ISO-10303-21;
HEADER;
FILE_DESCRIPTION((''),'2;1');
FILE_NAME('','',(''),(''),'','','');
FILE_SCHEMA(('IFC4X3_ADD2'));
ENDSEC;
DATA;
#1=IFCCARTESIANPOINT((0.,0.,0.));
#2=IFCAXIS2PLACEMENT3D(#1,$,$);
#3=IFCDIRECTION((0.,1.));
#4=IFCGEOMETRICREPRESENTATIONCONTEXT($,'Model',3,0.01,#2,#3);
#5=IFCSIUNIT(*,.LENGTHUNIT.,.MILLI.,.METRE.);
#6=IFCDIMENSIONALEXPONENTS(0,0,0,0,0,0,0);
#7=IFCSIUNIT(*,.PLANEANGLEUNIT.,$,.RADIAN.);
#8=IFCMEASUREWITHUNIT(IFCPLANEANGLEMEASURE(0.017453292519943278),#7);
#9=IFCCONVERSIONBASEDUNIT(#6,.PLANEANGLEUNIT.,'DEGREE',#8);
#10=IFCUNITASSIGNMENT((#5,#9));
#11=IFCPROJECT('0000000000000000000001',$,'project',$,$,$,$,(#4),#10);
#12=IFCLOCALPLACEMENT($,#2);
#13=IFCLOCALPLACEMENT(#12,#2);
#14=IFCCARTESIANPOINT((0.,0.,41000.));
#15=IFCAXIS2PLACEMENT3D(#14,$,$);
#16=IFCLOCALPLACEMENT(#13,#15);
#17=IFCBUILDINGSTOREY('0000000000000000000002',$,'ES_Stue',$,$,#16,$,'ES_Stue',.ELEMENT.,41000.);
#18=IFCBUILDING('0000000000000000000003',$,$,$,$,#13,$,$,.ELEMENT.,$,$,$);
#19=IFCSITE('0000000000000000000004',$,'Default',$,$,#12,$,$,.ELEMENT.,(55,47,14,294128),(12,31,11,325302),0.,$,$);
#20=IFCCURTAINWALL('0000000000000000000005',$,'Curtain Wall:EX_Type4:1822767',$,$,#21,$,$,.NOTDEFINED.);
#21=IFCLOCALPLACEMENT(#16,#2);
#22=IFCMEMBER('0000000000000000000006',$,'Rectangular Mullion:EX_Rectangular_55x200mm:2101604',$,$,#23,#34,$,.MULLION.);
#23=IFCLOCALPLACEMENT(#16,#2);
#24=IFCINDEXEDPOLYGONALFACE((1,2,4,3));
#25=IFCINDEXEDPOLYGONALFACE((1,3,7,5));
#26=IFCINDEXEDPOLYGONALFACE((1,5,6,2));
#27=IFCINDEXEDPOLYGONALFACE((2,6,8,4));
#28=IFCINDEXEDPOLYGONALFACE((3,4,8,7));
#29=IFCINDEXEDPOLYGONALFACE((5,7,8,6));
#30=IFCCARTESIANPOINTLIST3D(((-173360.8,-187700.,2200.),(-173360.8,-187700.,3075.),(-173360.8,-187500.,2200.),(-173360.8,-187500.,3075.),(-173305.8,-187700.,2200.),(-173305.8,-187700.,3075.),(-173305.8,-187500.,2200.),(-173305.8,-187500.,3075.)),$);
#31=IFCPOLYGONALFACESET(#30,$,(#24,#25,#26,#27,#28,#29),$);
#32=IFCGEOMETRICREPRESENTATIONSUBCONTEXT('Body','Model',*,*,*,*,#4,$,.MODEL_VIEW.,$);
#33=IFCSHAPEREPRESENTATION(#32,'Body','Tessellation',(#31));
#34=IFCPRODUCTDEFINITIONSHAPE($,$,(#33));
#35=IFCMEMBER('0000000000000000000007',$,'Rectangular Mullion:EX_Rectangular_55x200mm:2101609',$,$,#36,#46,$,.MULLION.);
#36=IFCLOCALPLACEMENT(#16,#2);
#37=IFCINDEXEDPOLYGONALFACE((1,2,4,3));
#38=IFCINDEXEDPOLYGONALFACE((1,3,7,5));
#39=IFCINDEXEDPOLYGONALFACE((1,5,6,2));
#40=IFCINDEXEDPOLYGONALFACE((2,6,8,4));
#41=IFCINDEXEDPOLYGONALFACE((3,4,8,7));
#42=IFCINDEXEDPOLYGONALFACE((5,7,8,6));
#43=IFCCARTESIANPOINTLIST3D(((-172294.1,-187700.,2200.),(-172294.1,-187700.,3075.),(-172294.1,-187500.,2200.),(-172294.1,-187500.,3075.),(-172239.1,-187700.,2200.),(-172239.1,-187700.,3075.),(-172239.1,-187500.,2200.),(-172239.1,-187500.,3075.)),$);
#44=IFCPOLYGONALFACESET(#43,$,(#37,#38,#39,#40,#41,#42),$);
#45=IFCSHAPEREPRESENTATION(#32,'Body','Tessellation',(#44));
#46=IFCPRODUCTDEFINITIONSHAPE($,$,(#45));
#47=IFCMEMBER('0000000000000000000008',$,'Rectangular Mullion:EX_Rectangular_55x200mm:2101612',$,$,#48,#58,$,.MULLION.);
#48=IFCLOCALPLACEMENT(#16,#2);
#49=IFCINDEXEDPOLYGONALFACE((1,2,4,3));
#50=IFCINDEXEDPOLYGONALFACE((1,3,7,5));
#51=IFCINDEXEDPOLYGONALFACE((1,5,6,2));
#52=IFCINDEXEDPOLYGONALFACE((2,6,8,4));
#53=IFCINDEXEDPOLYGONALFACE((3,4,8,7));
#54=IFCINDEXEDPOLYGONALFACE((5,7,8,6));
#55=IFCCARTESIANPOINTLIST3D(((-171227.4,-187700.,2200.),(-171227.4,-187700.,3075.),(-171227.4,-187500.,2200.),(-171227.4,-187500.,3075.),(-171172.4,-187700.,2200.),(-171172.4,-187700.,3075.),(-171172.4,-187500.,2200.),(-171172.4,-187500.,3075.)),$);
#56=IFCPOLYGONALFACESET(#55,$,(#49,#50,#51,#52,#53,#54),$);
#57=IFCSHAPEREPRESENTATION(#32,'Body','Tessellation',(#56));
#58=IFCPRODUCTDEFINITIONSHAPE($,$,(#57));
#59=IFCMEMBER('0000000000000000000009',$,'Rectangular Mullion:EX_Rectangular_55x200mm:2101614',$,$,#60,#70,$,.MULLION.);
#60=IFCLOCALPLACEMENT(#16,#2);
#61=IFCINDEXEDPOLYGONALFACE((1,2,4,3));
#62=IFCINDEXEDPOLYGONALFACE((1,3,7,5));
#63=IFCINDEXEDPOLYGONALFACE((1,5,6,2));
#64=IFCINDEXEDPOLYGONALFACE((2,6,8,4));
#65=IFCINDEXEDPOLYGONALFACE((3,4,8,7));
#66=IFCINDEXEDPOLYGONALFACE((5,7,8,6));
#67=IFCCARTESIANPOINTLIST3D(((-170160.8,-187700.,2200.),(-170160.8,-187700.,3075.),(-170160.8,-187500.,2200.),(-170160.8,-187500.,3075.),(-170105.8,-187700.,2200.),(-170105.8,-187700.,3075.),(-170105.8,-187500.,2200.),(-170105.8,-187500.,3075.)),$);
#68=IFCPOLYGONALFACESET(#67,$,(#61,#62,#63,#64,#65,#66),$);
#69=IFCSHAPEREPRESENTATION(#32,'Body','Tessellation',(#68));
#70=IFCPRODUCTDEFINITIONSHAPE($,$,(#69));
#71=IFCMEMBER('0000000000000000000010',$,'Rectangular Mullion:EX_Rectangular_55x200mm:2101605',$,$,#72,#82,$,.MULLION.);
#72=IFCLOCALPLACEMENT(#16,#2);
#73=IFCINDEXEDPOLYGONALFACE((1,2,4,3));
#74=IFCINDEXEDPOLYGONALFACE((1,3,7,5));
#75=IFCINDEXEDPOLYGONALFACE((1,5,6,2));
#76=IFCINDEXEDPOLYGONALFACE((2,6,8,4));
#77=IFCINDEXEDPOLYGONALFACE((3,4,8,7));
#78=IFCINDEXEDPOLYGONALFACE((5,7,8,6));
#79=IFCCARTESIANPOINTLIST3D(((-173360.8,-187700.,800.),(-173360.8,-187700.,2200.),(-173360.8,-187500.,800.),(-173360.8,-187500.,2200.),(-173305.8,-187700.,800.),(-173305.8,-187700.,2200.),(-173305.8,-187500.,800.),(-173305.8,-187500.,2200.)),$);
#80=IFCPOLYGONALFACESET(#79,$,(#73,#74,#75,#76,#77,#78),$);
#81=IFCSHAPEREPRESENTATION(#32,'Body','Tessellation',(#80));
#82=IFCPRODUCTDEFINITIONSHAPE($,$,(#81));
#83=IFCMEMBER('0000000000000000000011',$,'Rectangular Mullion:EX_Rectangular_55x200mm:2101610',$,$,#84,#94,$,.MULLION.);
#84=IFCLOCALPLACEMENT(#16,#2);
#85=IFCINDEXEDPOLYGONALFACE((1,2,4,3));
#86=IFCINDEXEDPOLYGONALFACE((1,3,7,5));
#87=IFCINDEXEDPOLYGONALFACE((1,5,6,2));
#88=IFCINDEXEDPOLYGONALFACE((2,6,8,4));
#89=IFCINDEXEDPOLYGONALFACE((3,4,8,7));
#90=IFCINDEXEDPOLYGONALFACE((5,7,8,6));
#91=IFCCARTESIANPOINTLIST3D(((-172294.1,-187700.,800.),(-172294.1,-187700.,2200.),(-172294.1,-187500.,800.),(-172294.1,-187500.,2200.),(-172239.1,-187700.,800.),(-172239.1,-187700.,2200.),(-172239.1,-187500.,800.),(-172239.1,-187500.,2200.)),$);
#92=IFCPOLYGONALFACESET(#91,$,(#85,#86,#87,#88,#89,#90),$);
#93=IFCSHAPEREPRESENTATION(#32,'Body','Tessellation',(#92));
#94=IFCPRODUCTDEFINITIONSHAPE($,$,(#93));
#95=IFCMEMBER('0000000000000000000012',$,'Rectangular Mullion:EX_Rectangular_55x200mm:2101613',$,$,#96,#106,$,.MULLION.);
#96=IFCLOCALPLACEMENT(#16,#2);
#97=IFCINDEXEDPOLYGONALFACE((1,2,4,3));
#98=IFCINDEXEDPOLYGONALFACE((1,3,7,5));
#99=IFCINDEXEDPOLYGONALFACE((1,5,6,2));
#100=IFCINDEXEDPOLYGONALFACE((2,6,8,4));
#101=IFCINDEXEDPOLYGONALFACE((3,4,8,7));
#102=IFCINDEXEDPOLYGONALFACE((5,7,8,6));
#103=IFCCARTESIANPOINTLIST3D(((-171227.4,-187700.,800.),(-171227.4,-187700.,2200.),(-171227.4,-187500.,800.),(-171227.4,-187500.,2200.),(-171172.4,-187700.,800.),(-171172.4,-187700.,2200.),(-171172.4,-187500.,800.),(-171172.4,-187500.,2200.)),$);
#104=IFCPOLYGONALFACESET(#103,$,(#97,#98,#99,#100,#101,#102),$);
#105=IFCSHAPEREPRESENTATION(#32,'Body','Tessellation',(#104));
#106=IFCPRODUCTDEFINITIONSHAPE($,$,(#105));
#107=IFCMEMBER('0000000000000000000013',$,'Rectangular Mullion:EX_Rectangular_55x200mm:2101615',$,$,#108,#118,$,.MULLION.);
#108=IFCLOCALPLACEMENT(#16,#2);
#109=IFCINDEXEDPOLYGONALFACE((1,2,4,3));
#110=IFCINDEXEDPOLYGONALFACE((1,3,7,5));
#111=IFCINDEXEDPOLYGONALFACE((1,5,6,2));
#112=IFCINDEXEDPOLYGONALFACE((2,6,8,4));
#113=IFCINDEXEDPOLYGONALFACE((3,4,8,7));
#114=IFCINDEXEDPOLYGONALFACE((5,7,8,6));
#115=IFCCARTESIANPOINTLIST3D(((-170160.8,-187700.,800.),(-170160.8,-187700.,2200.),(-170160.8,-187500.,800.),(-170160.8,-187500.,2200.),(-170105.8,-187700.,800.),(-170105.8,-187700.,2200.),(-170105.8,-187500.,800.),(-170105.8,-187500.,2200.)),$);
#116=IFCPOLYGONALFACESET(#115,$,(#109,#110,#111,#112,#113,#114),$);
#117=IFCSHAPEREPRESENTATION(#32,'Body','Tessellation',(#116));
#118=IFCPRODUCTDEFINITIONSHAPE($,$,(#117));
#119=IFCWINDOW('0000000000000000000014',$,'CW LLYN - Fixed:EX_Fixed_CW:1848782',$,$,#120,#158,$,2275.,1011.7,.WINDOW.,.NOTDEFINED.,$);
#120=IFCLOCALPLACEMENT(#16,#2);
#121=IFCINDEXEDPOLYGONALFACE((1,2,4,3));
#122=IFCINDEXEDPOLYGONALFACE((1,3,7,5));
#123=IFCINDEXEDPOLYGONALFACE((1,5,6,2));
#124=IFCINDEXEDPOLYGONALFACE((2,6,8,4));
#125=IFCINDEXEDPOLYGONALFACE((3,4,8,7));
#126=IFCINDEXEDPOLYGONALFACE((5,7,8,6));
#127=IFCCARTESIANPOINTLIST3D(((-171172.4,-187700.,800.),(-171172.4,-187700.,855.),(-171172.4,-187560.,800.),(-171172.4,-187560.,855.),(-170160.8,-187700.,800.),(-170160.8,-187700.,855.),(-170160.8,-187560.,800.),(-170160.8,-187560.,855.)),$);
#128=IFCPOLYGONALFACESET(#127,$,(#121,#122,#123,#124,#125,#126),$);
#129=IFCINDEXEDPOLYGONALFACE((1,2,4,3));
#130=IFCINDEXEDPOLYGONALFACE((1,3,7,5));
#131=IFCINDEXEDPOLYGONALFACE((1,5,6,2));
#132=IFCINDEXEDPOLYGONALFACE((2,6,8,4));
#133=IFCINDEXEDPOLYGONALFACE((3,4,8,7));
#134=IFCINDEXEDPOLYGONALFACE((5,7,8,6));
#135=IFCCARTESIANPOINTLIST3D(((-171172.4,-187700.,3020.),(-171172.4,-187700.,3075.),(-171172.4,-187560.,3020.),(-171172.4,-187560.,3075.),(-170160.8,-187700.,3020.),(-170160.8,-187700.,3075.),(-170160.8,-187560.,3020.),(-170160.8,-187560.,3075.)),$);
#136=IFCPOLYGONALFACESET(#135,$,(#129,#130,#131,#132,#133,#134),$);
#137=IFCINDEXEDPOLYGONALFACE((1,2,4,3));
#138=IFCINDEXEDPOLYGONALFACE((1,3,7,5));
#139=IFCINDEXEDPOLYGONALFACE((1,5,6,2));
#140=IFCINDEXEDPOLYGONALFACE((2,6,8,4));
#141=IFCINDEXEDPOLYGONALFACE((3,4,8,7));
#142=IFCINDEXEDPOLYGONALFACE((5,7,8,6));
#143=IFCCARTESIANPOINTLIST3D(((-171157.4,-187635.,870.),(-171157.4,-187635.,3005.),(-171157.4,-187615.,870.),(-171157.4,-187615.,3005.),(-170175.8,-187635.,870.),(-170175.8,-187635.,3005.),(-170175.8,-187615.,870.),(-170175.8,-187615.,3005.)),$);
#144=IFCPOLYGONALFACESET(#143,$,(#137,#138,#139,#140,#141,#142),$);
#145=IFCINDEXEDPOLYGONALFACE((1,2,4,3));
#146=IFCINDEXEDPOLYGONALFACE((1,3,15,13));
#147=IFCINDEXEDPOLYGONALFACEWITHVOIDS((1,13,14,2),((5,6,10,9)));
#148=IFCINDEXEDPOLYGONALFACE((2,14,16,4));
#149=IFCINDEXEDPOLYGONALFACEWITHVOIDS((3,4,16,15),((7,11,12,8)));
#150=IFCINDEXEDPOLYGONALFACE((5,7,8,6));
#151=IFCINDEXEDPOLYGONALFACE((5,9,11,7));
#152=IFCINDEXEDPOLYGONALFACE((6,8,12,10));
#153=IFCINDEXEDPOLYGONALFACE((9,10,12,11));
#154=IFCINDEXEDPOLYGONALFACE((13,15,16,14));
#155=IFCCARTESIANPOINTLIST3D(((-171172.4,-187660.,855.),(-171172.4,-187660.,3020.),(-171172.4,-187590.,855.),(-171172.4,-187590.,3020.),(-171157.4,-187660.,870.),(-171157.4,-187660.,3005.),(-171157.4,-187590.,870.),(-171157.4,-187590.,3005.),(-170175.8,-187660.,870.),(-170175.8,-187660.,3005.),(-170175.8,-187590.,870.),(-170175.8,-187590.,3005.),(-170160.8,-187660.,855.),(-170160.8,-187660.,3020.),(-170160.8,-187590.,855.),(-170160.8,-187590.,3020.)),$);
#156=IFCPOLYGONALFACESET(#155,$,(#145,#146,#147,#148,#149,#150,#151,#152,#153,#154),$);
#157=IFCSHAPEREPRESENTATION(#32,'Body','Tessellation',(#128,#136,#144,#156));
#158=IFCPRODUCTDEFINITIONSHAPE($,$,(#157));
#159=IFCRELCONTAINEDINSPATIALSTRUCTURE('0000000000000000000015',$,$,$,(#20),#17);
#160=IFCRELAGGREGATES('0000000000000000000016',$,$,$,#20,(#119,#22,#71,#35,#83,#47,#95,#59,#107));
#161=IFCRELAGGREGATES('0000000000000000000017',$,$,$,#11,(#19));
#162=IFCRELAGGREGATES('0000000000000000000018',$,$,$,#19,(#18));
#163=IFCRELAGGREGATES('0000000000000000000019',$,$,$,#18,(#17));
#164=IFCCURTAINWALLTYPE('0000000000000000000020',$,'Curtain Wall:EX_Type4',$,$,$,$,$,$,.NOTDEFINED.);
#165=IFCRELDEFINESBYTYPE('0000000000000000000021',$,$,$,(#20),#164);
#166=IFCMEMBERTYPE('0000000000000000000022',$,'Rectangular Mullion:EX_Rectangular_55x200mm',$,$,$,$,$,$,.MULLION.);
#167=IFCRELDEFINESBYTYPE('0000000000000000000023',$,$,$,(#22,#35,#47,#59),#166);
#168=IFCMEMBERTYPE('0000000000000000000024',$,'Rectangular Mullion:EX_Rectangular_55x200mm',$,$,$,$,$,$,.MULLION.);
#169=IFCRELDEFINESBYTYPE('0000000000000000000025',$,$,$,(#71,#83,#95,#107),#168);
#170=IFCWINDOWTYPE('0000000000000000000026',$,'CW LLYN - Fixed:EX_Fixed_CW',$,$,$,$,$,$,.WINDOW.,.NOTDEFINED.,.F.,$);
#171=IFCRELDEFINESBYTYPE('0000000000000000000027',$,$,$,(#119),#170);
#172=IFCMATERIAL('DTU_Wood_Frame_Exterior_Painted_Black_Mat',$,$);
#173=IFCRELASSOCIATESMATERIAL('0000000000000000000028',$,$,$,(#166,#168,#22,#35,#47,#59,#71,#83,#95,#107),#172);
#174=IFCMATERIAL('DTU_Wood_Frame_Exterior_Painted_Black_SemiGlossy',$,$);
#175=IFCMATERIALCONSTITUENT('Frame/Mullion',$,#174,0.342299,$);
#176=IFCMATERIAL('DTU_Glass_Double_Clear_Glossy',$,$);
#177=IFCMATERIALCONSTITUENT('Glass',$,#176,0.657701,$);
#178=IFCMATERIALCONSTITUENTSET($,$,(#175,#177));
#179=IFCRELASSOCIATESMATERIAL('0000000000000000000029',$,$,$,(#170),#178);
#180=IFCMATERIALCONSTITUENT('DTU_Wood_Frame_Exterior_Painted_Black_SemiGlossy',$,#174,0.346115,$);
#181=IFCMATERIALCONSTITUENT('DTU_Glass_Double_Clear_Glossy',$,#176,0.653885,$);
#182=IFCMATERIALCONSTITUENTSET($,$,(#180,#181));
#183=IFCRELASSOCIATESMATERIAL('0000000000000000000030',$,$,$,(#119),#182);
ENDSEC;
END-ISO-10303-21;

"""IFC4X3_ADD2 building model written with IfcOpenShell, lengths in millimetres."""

from ifc_helpers import new_model, entity, si_unit, converted_unit, direction, frame, frame_2d, origin, origin_2d_with_axis, place, context, subcontext, project, spatial, polyline, rectangle, outline, extrude, source, transform, mapped, material, constituent, constituent_set, material_profile, profile_set, profile_usage, type_object, type_shapes, element, aggregate, save


model = new_model("IFC4X3_ADD2")

# Units and contexts
model_context = context("Model", 3, precision=0.01, world=origin(), true_north=direction((0.0, 1.0)))
body_context = subcontext(model_context, "Body", "Model", "MODEL_VIEW")
ifc_project = project(units=[si_unit("LENGTHUNIT", "METRE", prefix="MILLI"), converted_unit("PLANEANGLEUNIT", "DEGREE", entity("IfcPlaneAngleMeasure", 0.017453292519943278), si_unit("PLANEANGLEUNIT", "RADIAN"), dimensions=[0, 0, 0, 0, 0, 0, 0])], contexts=[model_context])

# Site, building, storey
site_placement = place(None, origin())
site = spatial("IfcSite", under=ifc_project, at=site_placement, Name="Default", CompositionType="ELEMENT", RefLatitude=(55, 47, 14, 294128), RefLongitude=(12, 31, 11, 325302), RefElevation=0.0)
building_placement = place(site_placement, origin())
building = spatial("IfcBuilding", under=site, at=building_placement, CompositionType="ELEMENT")
storey_placement = place(building_placement, frame((0.0, 0.0, 41000.0)))
storey = spatial("IfcBuildingStorey", under=building, at=storey_placement, Name="ES_Stue", LongName="ES_Stue", CompositionType="ELEMENT", Elevation=41000.0)

# Curtain wall, members, window
curtain_wall_type = type_object("IfcCurtainWallType", Name="Curtain Wall:EX_Type4", PredefinedType="NOTDEFINED")
curtain_wall_placement = place(storey_placement, frame((0.0, 0.0, -41000.0)))
curtain_wall = element("IfcCurtainWall", 1, at=curtain_wall_placement, inside=storey, type_object=curtain_wall_type, Name="Curtain Wall:EX_Type4:1822767", PredefinedType="NOTDEFINED")
ifc_material_1 = material(Name="DTU_Wood_Frame_Exterior_Painted_Black_Mat")
ifc_material_profile = material_profile(ifc_material_1, rectangle(XDim=55.0, YDim=200.0, at=origin_2d_with_axis()), Name="EX_Rectangular_55x200mm")
ifc_profile_set = profile_set([ifc_material_profile], Name="EX_Rectangular_55x200mm")
ifc_profile_usage = profile_usage(ifc_profile_set)
member_type_1 = type_object("IfcMemberType", Name="Rectangular Mullion:EX_Rectangular_55x200mm", PredefinedType="MULLION", material=ifc_profile_set)
shared_shape_1 = source(origin(), body_context, "Body", "SweptSolid", [
    extrude(rectangle(XDim=55.0, YDim=200.0, at=origin_2d_with_axis()), frame((0.0, -100.0, -875.0), z_axis=(0.0, 0.0, 1.0), x_axis=(-1.0, 0.0, 0.0)), (0.0, 0.0, 1.0), 875.0),
])
type_shapes(member_type_1, [shared_shape_1])
member_1_placement = place(curtain_wall_placement, frame((-173333.3, -187500.0, 43200.0), z_axis=(0.0, 0.0, -1.0), x_axis=(-1.0, 0.0, 0.0)))
member_1 = element("IfcMember", 2, at=member_1_placement, type_object=member_type_1, material=ifc_profile_usage, Name="Rectangular Mullion:EX_Rectangular_55x200mm:2101604", PredefinedType="MULLION", context=body_context, shape_type="MappedRepresentation", body=[
    mapped(shared_shape_1, transform((0.0, 0.0, 0.0), scale=1.0)),
])
member_2_placement = place(curtain_wall_placement, frame((-172266.6, -187500.0, 43200.0), z_axis=(0.0, 0.0, -1.0), x_axis=(-1.0, 0.0, 0.0)))
member_2 = element("IfcMember", 3, at=member_2_placement, type_object=member_type_1, material=ifc_profile_usage, Name="Rectangular Mullion:EX_Rectangular_55x200mm:2101609", PredefinedType="MULLION", context=body_context, shape_type="MappedRepresentation", body=[
    mapped(shared_shape_1, transform((0.0, 0.0, 0.0), scale=1.0)),
])
member_3_placement = place(curtain_wall_placement, frame((-171199.9, -187500.0, 43200.0), z_axis=(0.0, 0.0, -1.0), x_axis=(-1.0, 0.0, 0.0)))
member_3 = element("IfcMember", 4, at=member_3_placement, type_object=member_type_1, material=ifc_profile_usage, Name="Rectangular Mullion:EX_Rectangular_55x200mm:2101612", PredefinedType="MULLION", context=body_context, shape_type="MappedRepresentation", body=[
    mapped(shared_shape_1, transform((0.0, 0.0, 0.0), scale=1.0)),
])
member_4_placement = place(curtain_wall_placement, frame((-170133.3, -187500.0, 43200.0), z_axis=(0.0, 0.0, -1.0), x_axis=(-1.0, 0.0, 0.0)))
member_4 = element("IfcMember", 5, at=member_4_placement, type_object=member_type_1, material=ifc_profile_usage, Name="Rectangular Mullion:EX_Rectangular_55x200mm:2101614", PredefinedType="MULLION", context=body_context, shape_type="MappedRepresentation", body=[
    mapped(shared_shape_1, transform((0.0, 0.0, 0.0), scale=1.0)),
])
member_type_2 = type_object("IfcMemberType", Name="Rectangular Mullion:EX_Rectangular_55x200mm", PredefinedType="MULLION", material=ifc_profile_set)
shared_shape_2 = source(origin(), body_context, "Body", "SweptSolid", [
    extrude(rectangle(XDim=55.0, YDim=200.0, at=origin_2d_with_axis()), frame((0.0, -100.0, -1400.0), z_axis=(0.0, 0.0, 1.0), x_axis=(-1.0, 0.0, 0.0)), (0.0, 0.0, 1.0), 1400.0),
])
type_shapes(member_type_2, [shared_shape_2])
member_5_placement = place(curtain_wall_placement, frame((-173333.3, -187500.0, 41800.0), z_axis=(0.0, 0.0, -1.0), x_axis=(-1.0, 0.0, 0.0)))
member_5 = element("IfcMember", 6, at=member_5_placement, type_object=member_type_2, material=ifc_profile_usage, Name="Rectangular Mullion:EX_Rectangular_55x200mm:2101605", PredefinedType="MULLION", context=body_context, shape_type="MappedRepresentation", body=[
    mapped(shared_shape_2, transform((0.0, 0.0, 0.0), scale=1.0)),
])
member_6_placement = place(curtain_wall_placement, frame((-172266.6, -187500.0, 41800.0), z_axis=(0.0, 0.0, -1.0), x_axis=(-1.0, 0.0, 0.0)))
member_6 = element("IfcMember", 7, at=member_6_placement, type_object=member_type_2, material=ifc_profile_usage, Name="Rectangular Mullion:EX_Rectangular_55x200mm:2101610", PredefinedType="MULLION", context=body_context, shape_type="MappedRepresentation", body=[
    mapped(shared_shape_2, transform((0.0, 0.0, 0.0), scale=1.0)),
])
member_7_placement = place(curtain_wall_placement, frame((-171199.9, -187500.0, 41800.0), z_axis=(0.0, 0.0, -1.0), x_axis=(-1.0, 0.0, 0.0)))
member_7 = element("IfcMember", 8, at=member_7_placement, type_object=member_type_2, material=ifc_profile_usage, Name="Rectangular Mullion:EX_Rectangular_55x200mm:2101613", PredefinedType="MULLION", context=body_context, shape_type="MappedRepresentation", body=[
    mapped(shared_shape_2, transform((0.0, 0.0, 0.0), scale=1.0)),
])
member_8_placement = place(curtain_wall_placement, frame((-170133.3, -187500.0, 41800.0), z_axis=(0.0, 0.0, -1.0), x_axis=(-1.0, 0.0, 0.0)))
member_8 = element("IfcMember", 9, at=member_8_placement, type_object=member_type_2, material=ifc_profile_usage, Name="Rectangular Mullion:EX_Rectangular_55x200mm:2101615", PredefinedType="MULLION", context=body_context, shape_type="MappedRepresentation", body=[
    mapped(shared_shape_2, transform((0.0, 0.0, 0.0), scale=1.0)),
])
ifc_material_2 = material(Name="DTU_Wood_Frame_Exterior_Painted_Black_SemiGlossy")
ifc_constituent_1 = constituent(ifc_material_2, Name="DTU_Wood_Frame_Exterior_Painted_Black_SemiGlossy", fraction=0.346115)
ifc_material_3 = material(Name="DTU_Glass_Double_Clear_Glossy")
ifc_constituent_2 = constituent(ifc_material_3, Name="DTU_Glass_Double_Clear_Glossy", fraction=0.653885)
ifc_constituent_set_1 = constituent_set(constituents=[ifc_constituent_1, ifc_constituent_2])
ifc_constituent_3 = constituent(ifc_material_2, Name="Frame/Mullion", fraction=0.342299)
ifc_constituent_4 = constituent(ifc_material_3, Name="Glass", fraction=0.657701)
ifc_constituent_set_2 = constituent_set(constituents=[ifc_constituent_3, ifc_constituent_4])
window_type_1 = type_object("IfcWindowType", Name="CW LLYN - Fixed:EX_Fixed_CW", ParameterTakesPrecedence=False, PartitioningType="NOTDEFINED", PredefinedType="WINDOW", material=ifc_constituent_set_2)
shared_shape_3 = source(origin(), body_context, "Body", "SweptSolid", [
    extrude(rectangle(XDim=140.0, YDim=1011.7, at=origin_2d_with_axis()), frame((0.0, -130.0, 0.0), z_axis=(0.0, 0.0, 1.0), x_axis=(0.0, -1.0, 0.0)), (0.0, 0.0, 1.0), 55.0),
    extrude(rectangle(XDim=140.0, YDim=1011.7, at=frame_2d((0.0, 0.0), x_axis=(1.0, 0.0))), frame((0.0, -130.0, 2220.0), z_axis=(0.0, 0.0, 1.0), x_axis=(0.0, -1.0, 0.0)), (0.0, 0.0, 1.0), 55.0),
    extrude(rectangle(XDim=981.7, YDim=20.0, at=frame_2d((0.0, 0.0), x_axis=(1.0, 0.0))), frame((0.0, -125.0, 70.0), z_axis=(0.0, 0.0, 1.0), x_axis=(-1.0, 0.0, 0.0)), (0.0, 0.0, 1.0), 2135.0),
    extrude(outline(polyline([(-1082.5, -505.8), (1082.5, -505.8), (1082.5, 505.8), (-1082.5, 505.8), (-1082.5, -505.8)]), holes=[polyline([(-1067.5, 490.8), (1067.5, 490.8), (1067.5, -490.8), (-1067.5, -490.8), (-1067.5, 490.8)])]), frame((0.0, -90.0, 1137.5), z_axis=(0.0, -1.0, 0.0), x_axis=(0.0, 0.0, 1.0)), (0.0, 0.0, 1.0), 70.0),
])
type_shapes(window_type_1, [shared_shape_3])
window_1_placement = place(curtain_wall_placement, frame((-170666.6, -187500.0, 41800.0)))
window_1 = element("IfcWindow", 10, at=window_1_placement, type_object=window_type_1, material=ifc_constituent_set_1, Name="CW LLYN - Fixed:EX_Fixed_CW:1848782", OverallHeight=2275.0, OverallWidth=1011.7, PartitioningType="NOTDEFINED", PredefinedType="WINDOW", context=body_context, shape_type="MappedRepresentation", body=[
    mapped(shared_shape_3, transform((0.0, 0.0, 0.0), scale=1.0)),
])
aggregate(curtain_wall, [window_1, member_1, member_5, member_2, member_6, member_3, member_7, member_4, member_8])

save(model, "model.ifc")
